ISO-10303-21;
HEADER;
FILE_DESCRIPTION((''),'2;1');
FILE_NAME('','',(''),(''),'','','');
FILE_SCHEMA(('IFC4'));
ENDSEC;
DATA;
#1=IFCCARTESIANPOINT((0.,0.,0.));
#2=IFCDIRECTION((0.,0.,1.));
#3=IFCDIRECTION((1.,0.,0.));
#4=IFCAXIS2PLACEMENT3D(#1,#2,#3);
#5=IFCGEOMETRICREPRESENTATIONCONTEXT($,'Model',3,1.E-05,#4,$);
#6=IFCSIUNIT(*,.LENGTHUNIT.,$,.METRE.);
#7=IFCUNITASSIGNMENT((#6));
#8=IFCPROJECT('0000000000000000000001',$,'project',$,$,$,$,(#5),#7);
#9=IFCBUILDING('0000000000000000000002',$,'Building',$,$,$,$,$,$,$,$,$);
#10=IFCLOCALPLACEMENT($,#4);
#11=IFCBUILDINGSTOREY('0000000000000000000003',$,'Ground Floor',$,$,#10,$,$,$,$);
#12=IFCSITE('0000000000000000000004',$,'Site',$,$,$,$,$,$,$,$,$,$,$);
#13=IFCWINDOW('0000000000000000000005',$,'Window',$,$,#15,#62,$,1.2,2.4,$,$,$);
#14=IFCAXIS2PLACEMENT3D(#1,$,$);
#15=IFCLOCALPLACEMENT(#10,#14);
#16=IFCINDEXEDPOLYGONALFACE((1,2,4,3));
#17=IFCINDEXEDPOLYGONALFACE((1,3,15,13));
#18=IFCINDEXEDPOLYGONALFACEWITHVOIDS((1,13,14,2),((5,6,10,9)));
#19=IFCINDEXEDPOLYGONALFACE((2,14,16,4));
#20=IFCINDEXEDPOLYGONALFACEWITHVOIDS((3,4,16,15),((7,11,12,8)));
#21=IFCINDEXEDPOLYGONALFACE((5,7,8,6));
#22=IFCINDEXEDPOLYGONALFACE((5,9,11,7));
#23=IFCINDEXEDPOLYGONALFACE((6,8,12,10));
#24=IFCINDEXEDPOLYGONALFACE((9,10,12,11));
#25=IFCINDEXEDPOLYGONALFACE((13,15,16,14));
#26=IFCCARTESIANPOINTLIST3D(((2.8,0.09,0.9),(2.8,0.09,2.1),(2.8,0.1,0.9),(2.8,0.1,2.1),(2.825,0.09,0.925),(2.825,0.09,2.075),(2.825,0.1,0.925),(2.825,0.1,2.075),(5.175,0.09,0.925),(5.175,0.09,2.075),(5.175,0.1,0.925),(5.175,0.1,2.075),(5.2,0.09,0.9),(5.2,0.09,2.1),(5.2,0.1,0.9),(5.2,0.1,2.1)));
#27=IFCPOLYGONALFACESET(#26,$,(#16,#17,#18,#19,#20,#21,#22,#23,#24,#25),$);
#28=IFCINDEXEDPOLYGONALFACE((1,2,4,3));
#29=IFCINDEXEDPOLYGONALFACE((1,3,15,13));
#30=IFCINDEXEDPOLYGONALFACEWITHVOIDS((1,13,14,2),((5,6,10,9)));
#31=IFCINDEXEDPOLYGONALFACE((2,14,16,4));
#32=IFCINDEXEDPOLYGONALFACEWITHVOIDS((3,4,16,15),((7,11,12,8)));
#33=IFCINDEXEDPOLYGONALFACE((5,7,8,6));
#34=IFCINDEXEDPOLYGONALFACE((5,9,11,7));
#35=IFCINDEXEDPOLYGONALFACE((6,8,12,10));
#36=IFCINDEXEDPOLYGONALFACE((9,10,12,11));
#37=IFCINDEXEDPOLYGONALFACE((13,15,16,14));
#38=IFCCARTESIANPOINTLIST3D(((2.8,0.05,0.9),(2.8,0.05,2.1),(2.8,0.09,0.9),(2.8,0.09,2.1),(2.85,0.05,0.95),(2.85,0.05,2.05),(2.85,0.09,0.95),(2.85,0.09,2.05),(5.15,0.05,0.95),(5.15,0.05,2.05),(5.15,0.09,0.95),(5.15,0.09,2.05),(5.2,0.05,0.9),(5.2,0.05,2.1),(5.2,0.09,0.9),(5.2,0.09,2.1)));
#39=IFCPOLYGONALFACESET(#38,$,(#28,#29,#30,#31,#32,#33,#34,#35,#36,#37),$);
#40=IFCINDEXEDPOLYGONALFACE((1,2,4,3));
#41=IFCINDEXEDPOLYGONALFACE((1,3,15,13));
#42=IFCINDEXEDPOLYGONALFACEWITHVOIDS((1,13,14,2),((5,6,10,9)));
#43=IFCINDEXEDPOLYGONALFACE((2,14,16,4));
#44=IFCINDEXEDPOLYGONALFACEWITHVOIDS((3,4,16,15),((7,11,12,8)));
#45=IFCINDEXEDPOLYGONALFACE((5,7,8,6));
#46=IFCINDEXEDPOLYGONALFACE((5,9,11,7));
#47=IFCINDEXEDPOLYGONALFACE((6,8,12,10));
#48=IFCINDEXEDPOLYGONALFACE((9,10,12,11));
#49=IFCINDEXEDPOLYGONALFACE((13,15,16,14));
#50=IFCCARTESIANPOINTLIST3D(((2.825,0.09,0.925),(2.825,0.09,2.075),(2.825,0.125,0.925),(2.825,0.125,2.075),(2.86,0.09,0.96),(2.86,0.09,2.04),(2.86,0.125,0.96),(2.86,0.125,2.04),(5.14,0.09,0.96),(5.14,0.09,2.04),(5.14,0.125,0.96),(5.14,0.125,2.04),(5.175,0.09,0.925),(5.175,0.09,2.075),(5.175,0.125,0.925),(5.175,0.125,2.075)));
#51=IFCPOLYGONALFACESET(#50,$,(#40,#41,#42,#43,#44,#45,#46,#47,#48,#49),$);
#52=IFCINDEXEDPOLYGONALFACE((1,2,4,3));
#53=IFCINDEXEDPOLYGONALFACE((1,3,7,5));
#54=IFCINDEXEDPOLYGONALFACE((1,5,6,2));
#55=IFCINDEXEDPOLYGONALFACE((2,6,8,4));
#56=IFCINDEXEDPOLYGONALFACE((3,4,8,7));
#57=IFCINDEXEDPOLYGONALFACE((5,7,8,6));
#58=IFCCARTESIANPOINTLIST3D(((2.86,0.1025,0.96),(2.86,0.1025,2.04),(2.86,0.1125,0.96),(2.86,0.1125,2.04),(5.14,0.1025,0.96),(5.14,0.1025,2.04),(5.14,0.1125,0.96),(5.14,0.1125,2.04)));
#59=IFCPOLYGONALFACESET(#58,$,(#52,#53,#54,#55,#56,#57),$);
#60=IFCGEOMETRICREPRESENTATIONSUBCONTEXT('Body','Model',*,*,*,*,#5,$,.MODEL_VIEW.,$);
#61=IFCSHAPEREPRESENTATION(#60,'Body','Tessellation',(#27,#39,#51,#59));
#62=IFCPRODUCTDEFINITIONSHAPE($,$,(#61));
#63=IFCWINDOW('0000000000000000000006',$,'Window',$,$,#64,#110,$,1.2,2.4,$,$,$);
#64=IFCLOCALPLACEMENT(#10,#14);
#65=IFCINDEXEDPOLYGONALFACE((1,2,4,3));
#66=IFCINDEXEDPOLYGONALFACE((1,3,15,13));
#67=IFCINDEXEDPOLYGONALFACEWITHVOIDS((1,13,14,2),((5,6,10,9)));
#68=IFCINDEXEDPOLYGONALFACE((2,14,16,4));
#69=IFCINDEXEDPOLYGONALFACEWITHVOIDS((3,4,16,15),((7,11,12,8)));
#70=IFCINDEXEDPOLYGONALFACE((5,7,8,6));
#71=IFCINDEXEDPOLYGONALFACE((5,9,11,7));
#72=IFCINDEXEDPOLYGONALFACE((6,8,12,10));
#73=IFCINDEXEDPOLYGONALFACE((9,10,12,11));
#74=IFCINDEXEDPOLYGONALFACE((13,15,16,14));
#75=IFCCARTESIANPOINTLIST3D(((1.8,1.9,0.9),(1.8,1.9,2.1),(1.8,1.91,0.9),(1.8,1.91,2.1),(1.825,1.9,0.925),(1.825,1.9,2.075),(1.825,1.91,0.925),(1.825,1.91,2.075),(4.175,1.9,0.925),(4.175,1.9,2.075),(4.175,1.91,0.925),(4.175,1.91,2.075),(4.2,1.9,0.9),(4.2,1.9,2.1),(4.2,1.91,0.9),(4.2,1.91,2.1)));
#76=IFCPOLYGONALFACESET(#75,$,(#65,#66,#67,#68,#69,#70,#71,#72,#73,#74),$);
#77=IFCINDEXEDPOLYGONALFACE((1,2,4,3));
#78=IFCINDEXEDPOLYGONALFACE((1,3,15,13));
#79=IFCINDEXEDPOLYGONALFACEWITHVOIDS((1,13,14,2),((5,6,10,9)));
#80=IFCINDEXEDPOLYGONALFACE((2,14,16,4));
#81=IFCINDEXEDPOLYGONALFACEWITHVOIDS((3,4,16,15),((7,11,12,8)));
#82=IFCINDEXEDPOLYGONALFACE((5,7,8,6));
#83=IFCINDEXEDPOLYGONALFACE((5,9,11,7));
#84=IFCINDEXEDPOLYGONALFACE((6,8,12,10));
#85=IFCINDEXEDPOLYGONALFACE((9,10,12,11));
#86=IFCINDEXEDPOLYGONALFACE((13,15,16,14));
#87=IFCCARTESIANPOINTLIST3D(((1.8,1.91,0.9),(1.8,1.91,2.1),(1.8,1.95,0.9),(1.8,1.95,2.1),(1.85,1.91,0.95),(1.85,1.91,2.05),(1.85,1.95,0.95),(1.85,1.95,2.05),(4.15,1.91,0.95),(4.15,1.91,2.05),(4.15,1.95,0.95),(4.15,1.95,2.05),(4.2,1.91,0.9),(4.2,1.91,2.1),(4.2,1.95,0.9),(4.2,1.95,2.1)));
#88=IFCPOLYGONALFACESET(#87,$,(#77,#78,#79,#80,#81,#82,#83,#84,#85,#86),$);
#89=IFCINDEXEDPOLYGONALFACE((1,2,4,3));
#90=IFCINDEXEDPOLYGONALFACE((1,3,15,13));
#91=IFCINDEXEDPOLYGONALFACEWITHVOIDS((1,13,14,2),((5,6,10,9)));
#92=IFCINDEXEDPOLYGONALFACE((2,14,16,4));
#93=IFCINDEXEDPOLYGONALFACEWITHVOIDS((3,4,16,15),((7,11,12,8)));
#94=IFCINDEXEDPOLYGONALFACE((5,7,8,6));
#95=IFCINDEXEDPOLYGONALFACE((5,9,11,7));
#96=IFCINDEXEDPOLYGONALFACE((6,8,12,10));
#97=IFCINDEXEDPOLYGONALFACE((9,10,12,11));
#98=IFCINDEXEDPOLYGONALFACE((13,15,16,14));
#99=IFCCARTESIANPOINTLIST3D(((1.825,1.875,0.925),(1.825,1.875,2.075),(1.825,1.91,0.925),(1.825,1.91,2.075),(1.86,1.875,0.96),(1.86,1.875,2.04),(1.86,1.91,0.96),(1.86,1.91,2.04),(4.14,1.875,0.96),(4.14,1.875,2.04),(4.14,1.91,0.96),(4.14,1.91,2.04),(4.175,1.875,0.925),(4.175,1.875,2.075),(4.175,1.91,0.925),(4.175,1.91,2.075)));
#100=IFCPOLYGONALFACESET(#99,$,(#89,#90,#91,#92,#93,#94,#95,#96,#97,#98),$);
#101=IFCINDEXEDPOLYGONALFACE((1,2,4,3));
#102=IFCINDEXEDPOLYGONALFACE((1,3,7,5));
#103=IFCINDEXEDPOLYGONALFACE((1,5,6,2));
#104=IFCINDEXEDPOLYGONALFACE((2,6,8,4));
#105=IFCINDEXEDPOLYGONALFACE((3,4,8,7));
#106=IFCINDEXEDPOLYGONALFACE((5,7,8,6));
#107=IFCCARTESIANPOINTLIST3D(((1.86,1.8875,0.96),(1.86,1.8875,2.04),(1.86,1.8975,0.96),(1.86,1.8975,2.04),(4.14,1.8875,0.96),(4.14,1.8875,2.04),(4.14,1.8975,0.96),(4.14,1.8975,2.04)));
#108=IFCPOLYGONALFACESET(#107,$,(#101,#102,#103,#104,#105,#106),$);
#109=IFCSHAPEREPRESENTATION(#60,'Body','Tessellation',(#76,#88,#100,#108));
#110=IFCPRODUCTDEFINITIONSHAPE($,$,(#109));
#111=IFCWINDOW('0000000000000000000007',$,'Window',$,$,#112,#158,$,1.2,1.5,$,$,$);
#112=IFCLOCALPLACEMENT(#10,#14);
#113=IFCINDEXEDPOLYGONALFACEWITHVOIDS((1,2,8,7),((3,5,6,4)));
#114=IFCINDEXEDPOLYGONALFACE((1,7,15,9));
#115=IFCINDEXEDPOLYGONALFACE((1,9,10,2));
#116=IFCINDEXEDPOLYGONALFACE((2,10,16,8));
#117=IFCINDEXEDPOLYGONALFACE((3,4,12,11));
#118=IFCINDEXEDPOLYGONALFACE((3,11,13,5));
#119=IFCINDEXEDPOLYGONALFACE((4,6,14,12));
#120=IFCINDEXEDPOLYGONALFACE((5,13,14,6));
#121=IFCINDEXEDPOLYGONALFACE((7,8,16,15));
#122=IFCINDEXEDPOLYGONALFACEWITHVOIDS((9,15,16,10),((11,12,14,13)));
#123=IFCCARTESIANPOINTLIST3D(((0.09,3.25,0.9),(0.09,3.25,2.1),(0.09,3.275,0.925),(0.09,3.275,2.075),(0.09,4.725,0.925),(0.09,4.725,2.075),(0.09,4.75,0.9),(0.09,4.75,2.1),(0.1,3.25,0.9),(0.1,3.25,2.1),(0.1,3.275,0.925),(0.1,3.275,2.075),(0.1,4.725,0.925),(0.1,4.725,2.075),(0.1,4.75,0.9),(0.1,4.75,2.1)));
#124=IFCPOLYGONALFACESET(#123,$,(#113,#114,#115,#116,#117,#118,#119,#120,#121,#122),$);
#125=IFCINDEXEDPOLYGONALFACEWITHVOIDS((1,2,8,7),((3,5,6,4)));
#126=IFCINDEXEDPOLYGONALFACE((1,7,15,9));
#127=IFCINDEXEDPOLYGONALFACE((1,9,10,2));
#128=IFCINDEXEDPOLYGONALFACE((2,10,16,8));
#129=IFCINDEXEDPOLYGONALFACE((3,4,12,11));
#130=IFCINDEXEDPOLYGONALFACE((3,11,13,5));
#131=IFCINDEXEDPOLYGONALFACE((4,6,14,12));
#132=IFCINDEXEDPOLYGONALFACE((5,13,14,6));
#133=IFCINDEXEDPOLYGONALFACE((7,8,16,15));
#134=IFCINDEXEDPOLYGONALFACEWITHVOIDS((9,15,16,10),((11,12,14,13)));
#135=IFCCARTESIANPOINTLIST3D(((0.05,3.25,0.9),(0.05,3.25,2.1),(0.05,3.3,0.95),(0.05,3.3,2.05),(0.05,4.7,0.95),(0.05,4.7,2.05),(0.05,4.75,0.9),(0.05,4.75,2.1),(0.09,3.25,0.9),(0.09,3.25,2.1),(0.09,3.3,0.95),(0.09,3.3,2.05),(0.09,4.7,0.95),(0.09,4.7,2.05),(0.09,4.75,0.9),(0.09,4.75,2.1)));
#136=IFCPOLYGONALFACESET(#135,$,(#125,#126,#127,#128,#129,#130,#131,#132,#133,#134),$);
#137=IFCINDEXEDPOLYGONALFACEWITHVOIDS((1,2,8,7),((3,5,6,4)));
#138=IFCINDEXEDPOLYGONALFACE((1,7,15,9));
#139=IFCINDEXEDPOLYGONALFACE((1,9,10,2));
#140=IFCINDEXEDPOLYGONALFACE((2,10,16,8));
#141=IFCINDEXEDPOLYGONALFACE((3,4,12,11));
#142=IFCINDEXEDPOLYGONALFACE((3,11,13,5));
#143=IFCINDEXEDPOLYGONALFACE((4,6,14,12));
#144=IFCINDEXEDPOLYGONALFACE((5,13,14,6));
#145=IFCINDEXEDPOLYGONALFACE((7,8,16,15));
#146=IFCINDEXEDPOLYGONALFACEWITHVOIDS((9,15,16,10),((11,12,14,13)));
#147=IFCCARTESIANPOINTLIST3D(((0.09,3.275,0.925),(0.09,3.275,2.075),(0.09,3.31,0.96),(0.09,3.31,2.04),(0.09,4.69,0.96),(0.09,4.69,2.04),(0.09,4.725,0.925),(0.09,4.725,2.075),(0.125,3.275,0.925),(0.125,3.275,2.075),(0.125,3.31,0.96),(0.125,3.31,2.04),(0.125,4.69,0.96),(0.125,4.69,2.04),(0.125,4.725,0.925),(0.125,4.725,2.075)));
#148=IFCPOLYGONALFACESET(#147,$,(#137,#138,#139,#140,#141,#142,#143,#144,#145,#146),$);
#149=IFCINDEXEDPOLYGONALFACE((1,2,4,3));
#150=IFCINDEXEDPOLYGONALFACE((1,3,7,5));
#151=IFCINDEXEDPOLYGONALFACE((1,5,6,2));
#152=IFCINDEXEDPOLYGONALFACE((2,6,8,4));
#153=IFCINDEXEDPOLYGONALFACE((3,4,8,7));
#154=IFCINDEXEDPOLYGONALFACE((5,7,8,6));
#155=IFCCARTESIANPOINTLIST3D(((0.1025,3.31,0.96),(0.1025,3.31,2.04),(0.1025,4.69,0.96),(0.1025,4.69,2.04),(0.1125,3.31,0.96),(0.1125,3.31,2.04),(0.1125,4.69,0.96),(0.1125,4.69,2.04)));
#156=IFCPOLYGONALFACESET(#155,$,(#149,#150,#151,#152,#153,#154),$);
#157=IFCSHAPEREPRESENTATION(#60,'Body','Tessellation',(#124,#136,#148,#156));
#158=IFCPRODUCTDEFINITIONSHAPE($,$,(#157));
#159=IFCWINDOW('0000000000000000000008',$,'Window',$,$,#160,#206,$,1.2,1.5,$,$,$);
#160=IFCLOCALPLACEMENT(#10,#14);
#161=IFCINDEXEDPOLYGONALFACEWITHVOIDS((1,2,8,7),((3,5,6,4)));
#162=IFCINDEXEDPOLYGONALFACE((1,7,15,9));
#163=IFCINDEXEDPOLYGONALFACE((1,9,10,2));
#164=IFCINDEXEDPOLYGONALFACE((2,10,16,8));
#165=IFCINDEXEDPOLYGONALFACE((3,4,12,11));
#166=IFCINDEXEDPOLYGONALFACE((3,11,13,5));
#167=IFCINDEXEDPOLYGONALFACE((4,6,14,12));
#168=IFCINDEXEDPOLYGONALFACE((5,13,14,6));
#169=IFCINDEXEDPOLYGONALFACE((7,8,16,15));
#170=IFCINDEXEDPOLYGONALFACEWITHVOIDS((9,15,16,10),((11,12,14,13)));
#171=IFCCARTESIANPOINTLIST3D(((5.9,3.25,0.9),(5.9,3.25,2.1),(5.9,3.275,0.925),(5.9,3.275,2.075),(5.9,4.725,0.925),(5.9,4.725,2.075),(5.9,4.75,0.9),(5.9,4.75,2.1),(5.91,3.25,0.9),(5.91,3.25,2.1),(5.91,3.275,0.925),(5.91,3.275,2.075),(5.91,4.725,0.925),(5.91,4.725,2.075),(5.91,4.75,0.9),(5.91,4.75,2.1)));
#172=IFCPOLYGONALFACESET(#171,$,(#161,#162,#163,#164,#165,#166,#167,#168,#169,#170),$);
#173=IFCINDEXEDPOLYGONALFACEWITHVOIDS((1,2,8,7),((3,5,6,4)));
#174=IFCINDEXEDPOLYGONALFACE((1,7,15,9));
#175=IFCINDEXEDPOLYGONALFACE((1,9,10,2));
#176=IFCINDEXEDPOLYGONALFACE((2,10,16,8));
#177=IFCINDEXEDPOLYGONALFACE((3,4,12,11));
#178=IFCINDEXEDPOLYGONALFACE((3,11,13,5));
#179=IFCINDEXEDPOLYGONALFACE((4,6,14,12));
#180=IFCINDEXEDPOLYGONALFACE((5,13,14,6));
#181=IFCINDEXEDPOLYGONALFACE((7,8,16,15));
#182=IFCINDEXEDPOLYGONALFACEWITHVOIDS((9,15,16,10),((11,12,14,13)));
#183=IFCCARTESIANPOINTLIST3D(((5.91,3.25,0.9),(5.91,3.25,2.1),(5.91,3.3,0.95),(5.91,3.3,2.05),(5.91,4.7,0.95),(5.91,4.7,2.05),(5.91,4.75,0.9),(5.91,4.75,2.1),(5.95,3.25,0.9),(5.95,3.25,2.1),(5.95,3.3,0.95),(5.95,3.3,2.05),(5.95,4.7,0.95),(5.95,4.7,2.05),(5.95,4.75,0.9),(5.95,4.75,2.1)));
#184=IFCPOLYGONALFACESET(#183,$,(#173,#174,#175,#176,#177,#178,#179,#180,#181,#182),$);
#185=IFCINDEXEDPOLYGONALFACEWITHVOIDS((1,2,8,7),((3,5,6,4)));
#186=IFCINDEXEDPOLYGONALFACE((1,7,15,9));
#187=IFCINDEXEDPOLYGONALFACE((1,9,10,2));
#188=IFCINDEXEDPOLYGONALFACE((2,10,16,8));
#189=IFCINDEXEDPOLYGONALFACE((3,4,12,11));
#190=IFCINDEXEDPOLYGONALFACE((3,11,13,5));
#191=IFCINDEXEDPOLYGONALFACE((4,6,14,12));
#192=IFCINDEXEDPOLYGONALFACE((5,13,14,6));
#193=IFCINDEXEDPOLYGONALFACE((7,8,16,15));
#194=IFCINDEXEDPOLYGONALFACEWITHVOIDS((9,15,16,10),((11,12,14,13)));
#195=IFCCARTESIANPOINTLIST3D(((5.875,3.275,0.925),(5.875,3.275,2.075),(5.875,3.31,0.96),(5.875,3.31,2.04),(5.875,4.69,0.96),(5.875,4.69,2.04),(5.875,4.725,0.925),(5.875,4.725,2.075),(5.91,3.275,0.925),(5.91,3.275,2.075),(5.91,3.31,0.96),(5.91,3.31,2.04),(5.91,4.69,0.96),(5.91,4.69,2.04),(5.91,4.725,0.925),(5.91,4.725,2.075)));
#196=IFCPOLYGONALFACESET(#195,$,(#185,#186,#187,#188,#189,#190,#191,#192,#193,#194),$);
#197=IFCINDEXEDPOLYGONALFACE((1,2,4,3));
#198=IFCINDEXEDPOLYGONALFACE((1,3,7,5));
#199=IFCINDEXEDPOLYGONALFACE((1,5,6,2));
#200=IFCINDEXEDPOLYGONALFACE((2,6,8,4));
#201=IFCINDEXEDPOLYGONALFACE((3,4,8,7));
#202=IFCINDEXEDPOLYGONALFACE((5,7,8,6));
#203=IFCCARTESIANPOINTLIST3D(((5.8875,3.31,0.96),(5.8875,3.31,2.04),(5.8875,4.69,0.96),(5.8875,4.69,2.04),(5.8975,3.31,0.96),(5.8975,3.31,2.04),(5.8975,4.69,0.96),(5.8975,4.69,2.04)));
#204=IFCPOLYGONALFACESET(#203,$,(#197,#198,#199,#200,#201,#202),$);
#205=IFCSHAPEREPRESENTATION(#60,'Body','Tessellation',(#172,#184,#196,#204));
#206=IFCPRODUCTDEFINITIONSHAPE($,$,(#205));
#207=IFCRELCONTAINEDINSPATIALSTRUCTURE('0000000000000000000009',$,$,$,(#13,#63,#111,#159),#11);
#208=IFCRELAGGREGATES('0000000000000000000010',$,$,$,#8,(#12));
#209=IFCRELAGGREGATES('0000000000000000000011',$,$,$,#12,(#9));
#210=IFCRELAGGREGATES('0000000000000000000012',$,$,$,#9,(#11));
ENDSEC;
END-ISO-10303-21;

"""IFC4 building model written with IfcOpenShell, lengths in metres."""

from ifc_helpers import new_model, si_unit, frame, origin_with_axes, place, context, subcontext, project, spatial, line, indexed_curve, outline, extrude, element, save


model = new_model("IFC4")

# Units and contexts
model_context = context("Model", 3, precision=1e-05, world=origin_with_axes())
body_context = subcontext(model_context, "Body", "Model", "MODEL_VIEW")
ifc_project = project(units=[si_unit("LENGTHUNIT", "METRE")], contexts=[model_context])

# Site, building, storey
site = spatial("IfcSite", under=ifc_project, Name="Site")
building = spatial("IfcBuilding", under=site, Name="Building")
storey_placement = place(None, origin_with_axes())
storey = spatial("IfcBuildingStorey", under=building, at=storey_placement, Name="Ground Floor")

# Windows
for number, where, z_axis, x_axis, name in (
    (1, (2.8, 0.0, 0.9), (0.0, 0.0, 1.0), (1.0, 0.0, 0.0), "Window"),
    (2, (4.2, 2.0, 0.9), (0.0, 0.0, 1.0), (-1.0, 0.0, 0.0), "Window"),
):
    element("IfcWindow", number, at=place(storey_placement, frame(where, z_axis=z_axis, x_axis=x_axis)), inside=storey, Name=name, OverallHeight=1.2, OverallWidth=2.4, context=body_context, shape_type="SweptSolid", body=[
        extrude(outline(indexed_curve([(0.0, 0.0), (2.4, 0.0), (2.4, 1.2), (0.0, 1.2)], segments=[line(1, 2, 3, 4, 1)]), holes=[indexed_curve([(0.025, 0.025), (2.375, 0.025), (2.375, 1.175), (0.025, 1.175)], segments=[line(1, 2, 3, 4, 1)])]), frame((0.0, 0.09, 0.0), z_axis=(0.0, -1.0, 0.0), x_axis=(1.0, 0.0, 0.0)), (0.0, 0.0, -1.0), 0.01),
        extrude(outline(indexed_curve([(0.0, 0.0), (2.4, 0.0), (2.4, 1.2), (0.0, 1.2)], segments=[line(1, 2, 3, 4, 1)]), holes=[indexed_curve([(0.05, 0.05), (2.35, 0.05), (2.35, 1.15), (0.05, 1.15)], segments=[line(1, 2, 3, 4, 1)])]), frame((0.0, 0.05, 0.0), z_axis=(0.0, -1.0, 0.0), x_axis=(1.0, 0.0, 0.0)), (0.0, 0.0, -1.0), 0.04),
        extrude(outline(indexed_curve([(0.0, 0.0), (2.35, 0.0), (2.35, 1.15), (0.0, 1.15)], segments=[line(1, 2, 3, 4, 1)]), holes=[indexed_curve([(0.035, 0.035), (2.315, 0.035), (2.315, 1.115), (0.035, 1.115)], segments=[line(1, 2, 3, 4, 1)])]), frame((0.025, 0.09, 0.025), z_axis=(0.0, -1.0, 0.0), x_axis=(1.0, 0.0, 0.0)), (0.0, 0.0, -1.0), 0.035),
        extrude(outline(indexed_curve([(0.035, 0.035), (2.315, 0.035), (2.315, 1.115), (0.035, 1.115)], segments=[line(1, 2, 3, 4, 1)])), frame((0.025, 0.1025, 0.025), z_axis=(0.0, -1.0, 0.0), x_axis=(1.0, 0.0, 0.0)), (0.0, 0.0, -1.0), 0.01),
    ])
for number, where, z_axis, x_axis, name in (
    (3, (0.0, 4.75, 0.9), (0.0, 0.0, 1.0), (0.0, -1.0, 0.0), "Window"),
    (4, (6.0, 3.25, 0.9), (0.0, 0.0, 1.0), (0.0, 1.0, 0.0), "Window"),
):
    element("IfcWindow", number, at=place(storey_placement, frame(where, z_axis=z_axis, x_axis=x_axis)), inside=storey, Name=name, OverallHeight=1.2, OverallWidth=1.5, context=body_context, shape_type="SweptSolid", body=[
        extrude(outline(indexed_curve([(0.0, 0.0), (1.5, 0.0), (1.5, 1.2), (0.0, 1.2)], segments=[line(1, 2, 3, 4, 1)]), holes=[indexed_curve([(0.025, 0.025), (1.475, 0.025), (1.475, 1.175), (0.025, 1.175)], segments=[line(1, 2, 3, 4, 1)])]), frame((0.0, 0.09, 0.0), z_axis=(0.0, -1.0, 0.0), x_axis=(1.0, 0.0, 0.0)), (0.0, 0.0, -1.0), 0.01),
        extrude(outline(indexed_curve([(0.0, 0.0), (1.5, 0.0), (1.5, 1.2), (0.0, 1.2)], segments=[line(1, 2, 3, 4, 1)]), holes=[indexed_curve([(0.05, 0.05), (1.45, 0.05), (1.45, 1.15), (0.05, 1.15)], segments=[line(1, 2, 3, 4, 1)])]), frame((0.0, 0.05, 0.0), z_axis=(0.0, -1.0, 0.0), x_axis=(1.0, 0.0, 0.0)), (0.0, 0.0, -1.0), 0.04),
        extrude(outline(indexed_curve([(0.0, 0.0), (1.45, 0.0), (1.45, 1.15), (0.0, 1.15)], segments=[line(1, 2, 3, 4, 1)]), holes=[indexed_curve([(0.035, 0.035), (1.415, 0.035), (1.415, 1.115), (0.035, 1.115)], segments=[line(1, 2, 3, 4, 1)])]), frame((0.025, 0.09, 0.025), z_axis=(0.0, -1.0, 0.0), x_axis=(1.0, 0.0, 0.0)), (0.0, 0.0, -1.0), 0.035),
        extrude(outline(indexed_curve([(0.035, 0.035), (1.415, 0.035), (1.415, 1.115), (0.035, 1.115)], segments=[line(1, 2, 3, 4, 1)])), frame((0.025, 0.1025, 0.025), z_axis=(0.0, -1.0, 0.0), x_axis=(1.0, 0.0, 0.0)), (0.0, 0.0, -1.0), 0.01),
    ])

save(model, "model.ifc")
